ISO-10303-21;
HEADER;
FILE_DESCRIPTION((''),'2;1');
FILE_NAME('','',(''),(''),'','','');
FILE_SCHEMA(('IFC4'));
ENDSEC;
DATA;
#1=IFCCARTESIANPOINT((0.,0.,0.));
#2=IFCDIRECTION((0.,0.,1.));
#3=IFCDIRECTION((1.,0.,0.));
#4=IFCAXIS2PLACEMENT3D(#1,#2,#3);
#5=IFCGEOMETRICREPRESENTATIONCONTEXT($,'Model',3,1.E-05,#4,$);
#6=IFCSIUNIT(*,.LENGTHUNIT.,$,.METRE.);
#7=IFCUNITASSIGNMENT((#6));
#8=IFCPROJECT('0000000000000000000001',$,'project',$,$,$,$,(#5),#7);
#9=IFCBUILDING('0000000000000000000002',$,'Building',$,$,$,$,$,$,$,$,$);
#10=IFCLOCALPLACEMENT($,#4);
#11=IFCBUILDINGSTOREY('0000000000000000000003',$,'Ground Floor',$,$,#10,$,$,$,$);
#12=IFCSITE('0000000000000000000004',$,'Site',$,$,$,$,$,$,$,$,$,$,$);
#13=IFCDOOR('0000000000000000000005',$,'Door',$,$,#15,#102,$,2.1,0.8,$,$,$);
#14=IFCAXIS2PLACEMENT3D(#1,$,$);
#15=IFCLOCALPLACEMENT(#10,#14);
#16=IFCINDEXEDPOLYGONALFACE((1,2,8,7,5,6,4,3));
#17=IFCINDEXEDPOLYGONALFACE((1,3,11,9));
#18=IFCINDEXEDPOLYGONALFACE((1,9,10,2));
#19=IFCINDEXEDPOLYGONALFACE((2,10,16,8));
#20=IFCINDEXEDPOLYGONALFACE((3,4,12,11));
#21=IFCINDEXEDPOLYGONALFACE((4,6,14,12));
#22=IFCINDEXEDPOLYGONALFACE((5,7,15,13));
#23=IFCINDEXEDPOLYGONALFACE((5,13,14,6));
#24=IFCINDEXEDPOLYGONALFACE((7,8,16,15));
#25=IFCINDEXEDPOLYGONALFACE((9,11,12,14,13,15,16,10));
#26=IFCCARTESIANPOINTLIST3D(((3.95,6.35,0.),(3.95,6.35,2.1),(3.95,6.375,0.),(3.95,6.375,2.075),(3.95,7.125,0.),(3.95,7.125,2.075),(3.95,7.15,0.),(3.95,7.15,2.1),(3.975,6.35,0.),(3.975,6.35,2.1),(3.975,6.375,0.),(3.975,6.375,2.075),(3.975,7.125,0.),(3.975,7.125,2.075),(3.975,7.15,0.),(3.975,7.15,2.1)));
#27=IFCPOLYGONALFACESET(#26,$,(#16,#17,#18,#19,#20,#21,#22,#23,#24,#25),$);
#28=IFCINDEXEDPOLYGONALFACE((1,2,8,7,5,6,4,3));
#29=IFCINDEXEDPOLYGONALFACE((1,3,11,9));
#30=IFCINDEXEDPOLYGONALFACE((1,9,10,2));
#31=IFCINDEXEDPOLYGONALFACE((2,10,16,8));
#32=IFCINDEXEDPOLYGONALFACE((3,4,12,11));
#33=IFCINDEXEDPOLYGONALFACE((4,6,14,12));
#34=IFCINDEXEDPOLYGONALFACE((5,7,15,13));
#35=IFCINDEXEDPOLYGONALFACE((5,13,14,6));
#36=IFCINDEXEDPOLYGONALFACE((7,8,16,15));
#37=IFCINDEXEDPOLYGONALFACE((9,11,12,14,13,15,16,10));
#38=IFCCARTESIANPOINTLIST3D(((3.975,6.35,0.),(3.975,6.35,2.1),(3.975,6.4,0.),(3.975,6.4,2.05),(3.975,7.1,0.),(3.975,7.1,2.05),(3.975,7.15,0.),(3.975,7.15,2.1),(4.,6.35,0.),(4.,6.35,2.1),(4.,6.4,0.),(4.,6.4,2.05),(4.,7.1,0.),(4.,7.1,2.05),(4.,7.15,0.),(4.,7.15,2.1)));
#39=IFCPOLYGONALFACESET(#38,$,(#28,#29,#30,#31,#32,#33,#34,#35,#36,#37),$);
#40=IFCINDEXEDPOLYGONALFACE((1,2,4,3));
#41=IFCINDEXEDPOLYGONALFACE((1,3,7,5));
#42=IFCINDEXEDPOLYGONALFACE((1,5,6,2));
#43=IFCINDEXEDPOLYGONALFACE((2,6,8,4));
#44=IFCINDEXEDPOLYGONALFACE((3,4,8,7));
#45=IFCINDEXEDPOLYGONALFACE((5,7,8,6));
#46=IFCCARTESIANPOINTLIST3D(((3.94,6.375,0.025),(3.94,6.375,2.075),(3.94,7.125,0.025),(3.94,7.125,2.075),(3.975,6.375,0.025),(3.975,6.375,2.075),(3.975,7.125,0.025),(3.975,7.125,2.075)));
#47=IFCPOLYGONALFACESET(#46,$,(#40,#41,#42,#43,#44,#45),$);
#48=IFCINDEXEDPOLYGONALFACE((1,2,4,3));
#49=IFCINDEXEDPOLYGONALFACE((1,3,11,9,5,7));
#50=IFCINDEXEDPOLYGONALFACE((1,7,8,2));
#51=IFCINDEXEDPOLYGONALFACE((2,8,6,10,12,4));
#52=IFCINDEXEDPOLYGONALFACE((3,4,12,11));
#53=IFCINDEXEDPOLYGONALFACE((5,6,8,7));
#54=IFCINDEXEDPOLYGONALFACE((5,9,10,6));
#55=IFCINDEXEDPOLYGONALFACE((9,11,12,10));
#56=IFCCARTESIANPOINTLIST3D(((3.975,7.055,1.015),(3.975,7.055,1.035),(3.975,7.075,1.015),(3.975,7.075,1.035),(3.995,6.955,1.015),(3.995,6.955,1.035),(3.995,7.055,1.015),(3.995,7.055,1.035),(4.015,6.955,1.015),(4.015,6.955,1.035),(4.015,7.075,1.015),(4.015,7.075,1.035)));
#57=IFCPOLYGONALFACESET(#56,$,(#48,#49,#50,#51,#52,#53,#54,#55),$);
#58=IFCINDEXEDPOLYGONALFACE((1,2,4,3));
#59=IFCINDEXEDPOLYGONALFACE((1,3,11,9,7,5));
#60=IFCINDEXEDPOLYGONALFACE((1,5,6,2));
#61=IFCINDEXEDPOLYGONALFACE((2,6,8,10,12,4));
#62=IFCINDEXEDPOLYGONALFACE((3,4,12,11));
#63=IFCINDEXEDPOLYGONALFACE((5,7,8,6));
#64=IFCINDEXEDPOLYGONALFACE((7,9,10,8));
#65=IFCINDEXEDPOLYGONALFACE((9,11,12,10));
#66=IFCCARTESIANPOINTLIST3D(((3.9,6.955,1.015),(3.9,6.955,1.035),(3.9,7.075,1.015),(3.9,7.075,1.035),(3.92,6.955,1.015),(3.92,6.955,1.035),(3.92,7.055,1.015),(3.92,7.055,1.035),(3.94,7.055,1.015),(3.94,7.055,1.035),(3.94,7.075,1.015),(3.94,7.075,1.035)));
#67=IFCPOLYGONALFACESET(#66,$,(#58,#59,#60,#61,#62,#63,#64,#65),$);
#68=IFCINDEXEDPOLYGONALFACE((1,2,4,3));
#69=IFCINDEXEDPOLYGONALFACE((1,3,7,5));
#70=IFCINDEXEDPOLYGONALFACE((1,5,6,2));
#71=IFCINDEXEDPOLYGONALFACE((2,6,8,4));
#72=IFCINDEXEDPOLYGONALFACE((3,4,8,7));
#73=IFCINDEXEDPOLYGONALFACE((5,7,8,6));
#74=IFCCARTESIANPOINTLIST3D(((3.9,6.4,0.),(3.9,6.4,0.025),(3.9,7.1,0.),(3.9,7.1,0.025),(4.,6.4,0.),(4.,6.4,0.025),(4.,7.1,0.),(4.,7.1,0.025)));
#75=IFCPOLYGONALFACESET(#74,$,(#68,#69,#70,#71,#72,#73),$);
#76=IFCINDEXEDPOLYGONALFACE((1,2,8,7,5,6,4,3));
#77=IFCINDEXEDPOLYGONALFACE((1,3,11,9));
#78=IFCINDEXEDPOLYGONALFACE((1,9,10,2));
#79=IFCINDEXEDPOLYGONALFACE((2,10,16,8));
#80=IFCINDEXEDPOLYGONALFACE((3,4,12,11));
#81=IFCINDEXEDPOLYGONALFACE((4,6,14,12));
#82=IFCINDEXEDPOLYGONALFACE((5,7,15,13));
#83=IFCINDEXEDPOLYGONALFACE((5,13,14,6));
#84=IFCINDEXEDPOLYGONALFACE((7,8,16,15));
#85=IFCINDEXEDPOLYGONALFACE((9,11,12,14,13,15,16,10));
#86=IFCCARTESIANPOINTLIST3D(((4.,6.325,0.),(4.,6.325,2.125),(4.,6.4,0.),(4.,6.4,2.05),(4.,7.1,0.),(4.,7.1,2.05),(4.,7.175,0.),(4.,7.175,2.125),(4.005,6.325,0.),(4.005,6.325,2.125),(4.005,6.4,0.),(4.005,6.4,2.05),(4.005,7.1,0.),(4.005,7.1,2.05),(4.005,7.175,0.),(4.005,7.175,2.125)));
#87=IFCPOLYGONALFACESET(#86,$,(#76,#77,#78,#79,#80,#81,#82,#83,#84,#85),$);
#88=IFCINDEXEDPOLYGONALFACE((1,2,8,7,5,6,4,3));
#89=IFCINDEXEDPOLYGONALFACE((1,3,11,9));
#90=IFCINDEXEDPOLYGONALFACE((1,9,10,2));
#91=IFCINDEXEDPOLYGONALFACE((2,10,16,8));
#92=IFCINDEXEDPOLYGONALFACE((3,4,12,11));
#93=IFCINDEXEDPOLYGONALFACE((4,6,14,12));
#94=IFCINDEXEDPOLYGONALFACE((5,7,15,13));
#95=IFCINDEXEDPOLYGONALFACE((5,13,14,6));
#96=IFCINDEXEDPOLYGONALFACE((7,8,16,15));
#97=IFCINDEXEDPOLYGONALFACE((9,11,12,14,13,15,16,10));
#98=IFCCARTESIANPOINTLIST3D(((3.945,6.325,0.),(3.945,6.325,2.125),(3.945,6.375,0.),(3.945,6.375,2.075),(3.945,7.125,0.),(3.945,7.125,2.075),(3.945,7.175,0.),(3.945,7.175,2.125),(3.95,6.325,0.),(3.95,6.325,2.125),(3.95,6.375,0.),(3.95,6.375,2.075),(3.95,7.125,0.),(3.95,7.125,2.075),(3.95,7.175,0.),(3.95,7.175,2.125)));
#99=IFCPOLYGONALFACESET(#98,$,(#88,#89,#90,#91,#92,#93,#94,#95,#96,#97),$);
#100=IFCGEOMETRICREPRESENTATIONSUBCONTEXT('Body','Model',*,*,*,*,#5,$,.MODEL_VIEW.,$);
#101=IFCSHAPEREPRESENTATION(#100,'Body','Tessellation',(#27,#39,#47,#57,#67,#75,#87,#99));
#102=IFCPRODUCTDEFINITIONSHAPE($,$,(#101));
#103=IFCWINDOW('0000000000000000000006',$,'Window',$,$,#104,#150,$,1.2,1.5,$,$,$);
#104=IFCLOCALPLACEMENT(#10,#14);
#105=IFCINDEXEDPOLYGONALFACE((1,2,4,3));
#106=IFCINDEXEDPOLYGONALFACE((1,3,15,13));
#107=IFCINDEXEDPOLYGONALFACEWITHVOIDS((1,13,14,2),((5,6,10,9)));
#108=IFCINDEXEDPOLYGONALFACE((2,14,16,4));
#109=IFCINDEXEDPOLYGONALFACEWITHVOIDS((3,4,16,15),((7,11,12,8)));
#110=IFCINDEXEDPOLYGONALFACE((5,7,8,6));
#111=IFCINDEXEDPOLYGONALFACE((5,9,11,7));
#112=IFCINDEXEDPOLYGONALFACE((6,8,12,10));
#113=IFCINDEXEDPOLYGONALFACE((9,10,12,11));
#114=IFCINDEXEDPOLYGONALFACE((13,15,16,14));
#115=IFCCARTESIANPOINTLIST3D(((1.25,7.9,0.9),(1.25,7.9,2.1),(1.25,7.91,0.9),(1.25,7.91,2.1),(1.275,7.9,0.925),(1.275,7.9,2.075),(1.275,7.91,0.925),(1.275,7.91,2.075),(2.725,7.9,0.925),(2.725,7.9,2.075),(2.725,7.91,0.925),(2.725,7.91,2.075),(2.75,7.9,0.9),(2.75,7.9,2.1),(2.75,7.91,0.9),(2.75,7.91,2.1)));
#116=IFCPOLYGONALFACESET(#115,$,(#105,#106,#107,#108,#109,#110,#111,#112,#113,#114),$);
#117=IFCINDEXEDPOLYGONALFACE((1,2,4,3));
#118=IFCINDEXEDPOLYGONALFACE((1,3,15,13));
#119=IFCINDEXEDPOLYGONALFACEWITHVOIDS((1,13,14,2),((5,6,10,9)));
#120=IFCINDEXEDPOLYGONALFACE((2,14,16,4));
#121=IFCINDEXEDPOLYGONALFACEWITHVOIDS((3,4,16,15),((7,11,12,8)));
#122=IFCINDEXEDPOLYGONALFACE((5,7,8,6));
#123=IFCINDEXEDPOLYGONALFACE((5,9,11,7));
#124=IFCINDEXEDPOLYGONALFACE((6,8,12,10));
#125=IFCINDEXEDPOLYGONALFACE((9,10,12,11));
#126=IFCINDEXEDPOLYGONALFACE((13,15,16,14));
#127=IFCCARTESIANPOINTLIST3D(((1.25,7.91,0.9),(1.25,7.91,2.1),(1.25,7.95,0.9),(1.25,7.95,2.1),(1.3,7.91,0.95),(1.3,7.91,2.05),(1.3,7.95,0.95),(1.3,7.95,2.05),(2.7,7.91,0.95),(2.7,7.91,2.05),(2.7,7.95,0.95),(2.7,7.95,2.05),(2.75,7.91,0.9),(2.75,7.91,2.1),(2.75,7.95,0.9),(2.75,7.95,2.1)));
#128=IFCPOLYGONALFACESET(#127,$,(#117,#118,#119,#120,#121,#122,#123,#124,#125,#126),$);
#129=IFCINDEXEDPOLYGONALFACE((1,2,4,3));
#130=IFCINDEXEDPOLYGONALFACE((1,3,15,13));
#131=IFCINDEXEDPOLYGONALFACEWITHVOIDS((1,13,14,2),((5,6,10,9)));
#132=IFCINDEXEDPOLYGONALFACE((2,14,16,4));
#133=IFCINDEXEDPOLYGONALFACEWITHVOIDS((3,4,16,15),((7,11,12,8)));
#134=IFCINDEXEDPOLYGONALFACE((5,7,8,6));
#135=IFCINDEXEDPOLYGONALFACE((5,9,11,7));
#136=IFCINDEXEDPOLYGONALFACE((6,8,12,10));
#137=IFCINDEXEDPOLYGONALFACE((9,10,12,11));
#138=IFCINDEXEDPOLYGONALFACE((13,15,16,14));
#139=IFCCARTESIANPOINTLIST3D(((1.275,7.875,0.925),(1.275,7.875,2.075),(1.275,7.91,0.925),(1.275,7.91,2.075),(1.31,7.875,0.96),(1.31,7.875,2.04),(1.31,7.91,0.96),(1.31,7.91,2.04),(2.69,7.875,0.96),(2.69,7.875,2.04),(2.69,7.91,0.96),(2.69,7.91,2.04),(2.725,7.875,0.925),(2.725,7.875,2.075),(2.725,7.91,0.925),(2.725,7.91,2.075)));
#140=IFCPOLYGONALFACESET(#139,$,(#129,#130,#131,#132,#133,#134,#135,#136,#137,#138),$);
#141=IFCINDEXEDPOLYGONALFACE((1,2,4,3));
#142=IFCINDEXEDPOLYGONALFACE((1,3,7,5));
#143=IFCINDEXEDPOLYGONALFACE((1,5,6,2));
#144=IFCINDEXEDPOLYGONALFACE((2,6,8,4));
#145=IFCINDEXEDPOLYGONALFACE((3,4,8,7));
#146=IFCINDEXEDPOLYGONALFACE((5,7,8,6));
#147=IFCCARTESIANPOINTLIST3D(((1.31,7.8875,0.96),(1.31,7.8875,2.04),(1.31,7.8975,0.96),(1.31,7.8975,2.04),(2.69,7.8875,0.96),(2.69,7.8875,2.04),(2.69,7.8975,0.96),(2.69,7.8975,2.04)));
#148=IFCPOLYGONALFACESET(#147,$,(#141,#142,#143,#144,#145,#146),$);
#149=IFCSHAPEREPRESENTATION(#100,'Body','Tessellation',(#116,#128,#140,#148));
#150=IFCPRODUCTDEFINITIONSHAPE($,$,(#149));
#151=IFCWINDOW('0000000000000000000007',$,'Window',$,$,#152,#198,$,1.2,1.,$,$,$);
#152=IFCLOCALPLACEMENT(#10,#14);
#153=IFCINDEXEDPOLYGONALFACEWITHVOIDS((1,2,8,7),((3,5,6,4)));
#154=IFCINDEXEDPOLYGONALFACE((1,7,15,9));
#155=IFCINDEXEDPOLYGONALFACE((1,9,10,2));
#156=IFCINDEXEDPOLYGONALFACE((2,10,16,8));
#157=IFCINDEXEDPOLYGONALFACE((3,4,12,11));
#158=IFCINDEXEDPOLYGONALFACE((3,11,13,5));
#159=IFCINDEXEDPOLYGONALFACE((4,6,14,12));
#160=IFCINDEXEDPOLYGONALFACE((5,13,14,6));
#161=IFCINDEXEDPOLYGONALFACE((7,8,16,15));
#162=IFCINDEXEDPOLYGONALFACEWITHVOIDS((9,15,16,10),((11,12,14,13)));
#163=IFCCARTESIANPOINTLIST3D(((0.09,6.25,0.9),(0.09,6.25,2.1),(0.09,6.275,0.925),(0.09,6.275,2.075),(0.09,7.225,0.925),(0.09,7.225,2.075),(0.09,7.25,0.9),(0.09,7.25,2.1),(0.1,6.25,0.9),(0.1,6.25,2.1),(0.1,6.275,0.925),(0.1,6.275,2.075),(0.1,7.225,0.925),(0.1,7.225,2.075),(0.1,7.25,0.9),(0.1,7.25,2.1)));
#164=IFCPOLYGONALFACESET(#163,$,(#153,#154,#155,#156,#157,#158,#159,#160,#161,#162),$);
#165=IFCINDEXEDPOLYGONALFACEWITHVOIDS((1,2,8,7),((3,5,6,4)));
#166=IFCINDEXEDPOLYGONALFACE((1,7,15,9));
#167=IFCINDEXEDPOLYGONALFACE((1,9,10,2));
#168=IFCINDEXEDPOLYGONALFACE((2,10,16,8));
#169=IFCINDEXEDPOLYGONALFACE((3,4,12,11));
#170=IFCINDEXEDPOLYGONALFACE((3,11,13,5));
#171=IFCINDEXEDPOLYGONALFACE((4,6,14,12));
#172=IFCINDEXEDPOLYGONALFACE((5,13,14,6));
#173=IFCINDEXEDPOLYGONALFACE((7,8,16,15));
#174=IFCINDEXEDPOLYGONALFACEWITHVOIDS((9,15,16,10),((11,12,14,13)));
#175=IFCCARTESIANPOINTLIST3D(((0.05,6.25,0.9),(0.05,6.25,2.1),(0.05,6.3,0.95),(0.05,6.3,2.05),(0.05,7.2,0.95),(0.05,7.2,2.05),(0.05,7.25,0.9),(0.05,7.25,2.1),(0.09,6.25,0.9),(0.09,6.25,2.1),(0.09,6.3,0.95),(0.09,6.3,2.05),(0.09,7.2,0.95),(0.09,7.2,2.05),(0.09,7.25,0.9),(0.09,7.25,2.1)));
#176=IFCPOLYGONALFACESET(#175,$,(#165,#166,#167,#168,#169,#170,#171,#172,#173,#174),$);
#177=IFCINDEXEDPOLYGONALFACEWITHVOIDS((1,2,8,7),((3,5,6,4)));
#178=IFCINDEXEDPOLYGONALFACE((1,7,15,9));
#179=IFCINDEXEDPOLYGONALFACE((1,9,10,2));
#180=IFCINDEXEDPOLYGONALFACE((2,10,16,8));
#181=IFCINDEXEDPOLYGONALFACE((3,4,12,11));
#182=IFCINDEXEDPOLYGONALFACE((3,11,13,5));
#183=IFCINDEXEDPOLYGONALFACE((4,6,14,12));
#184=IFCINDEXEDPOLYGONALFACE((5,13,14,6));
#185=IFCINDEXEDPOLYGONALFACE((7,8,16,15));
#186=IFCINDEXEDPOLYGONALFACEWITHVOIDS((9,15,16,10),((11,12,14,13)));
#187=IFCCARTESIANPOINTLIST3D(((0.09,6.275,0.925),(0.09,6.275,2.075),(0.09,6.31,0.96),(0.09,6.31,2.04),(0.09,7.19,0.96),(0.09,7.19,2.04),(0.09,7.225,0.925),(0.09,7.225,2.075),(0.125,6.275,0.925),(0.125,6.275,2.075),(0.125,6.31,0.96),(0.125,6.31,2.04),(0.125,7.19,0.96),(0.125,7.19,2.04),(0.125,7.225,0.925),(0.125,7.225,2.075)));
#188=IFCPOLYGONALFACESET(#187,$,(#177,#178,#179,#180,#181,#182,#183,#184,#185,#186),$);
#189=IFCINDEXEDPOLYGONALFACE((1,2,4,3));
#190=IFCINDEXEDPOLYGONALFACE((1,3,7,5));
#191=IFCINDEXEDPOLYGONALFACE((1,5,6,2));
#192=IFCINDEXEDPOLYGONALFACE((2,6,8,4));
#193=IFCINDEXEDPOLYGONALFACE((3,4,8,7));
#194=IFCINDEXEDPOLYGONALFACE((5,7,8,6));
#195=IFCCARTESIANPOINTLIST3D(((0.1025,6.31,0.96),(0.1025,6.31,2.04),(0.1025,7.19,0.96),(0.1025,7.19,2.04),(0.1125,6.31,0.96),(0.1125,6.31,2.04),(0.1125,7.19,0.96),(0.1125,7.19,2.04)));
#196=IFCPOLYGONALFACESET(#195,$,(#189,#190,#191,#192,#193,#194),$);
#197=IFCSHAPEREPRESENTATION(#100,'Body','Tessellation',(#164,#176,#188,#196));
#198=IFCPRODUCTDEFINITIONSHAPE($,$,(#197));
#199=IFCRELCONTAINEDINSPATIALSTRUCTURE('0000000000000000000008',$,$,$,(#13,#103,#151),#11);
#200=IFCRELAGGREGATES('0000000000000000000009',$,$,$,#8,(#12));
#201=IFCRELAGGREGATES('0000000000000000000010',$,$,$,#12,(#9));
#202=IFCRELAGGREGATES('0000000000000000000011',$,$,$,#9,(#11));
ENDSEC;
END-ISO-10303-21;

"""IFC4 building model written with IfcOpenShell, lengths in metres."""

from ifc_helpers import new_model, si_unit, frame, origin_with_axes, place, context, subcontext, project, spatial, line, indexed_curve, outline, extrude, element, save


model = new_model("IFC4")

# Units and contexts
model_context = context("Model", 3, precision=1e-05, world=origin_with_axes())
body_context = subcontext(model_context, "Body", "Model", "MODEL_VIEW")
ifc_project = project(units=[si_unit("LENGTHUNIT", "METRE")], contexts=[model_context])

# Site, building, storey
site = spatial("IfcSite", under=ifc_project, Name="Site")
building = spatial("IfcBuilding", under=site, Name="Building")
storey_placement = place(None, origin_with_axes())
storey = spatial("IfcBuildingStorey", under=building, at=storey_placement, Name="Ground Floor")

# Door
door_1_placement = place(storey_placement, frame((4.0, 6.35, 0.0), z_axis=(0.0, 0.0, 1.0), x_axis=(0.0, 1.0, 0.0)))
element("IfcDoor", 1, at=door_1_placement, inside=storey, Name="Door", OverallHeight=2.1, OverallWidth=0.8, context=body_context, shape_type="SweptSolid", body=[
    extrude(outline(indexed_curve([(0.0, 0.0), (0.0, 2.1), (0.8, 2.1), (0.8, 0.0), (0.775, 0.0), (0.775, 2.075), (0.025, 2.075), (0.025, 0.0)], segments=[line(1, 2, 3, 4, 5, 6, 7, 8, 1)])), frame((0.0, 0.025, 0.0), z_axis=(0.0, -1.0, 0.0), x_axis=(1.0, 0.0, 0.0)), (0.0, 0.0, -1.0), 0.025),
    extrude(outline(indexed_curve([(0.0, 0.0), (0.0, 2.1), (0.8, 2.1), (0.8, 0.0), (0.75, 0.0), (0.75, 2.05), (0.05, 2.05), (0.05, 0.0)], segments=[line(1, 2, 3, 4, 5, 6, 7, 8, 1)])), frame((0.0, 0.0, 0.0), z_axis=(0.0, -1.0, 0.0), x_axis=(1.0, 0.0, 0.0)), (0.0, 0.0, -1.0), 0.025),
    extrude(outline(indexed_curve([(0.0, 0.0), (0.75, 0.0), (0.75, 0.035), (0.0, 0.035)], segments=[line(1, 2, 3, 4, 1)])), frame((0.025, 0.025, 0.025), z_axis=(0.0, 0.0, 1.0), x_axis=(1.0, 0.0, 0.0)), (0.0, 0.0, 1.0), 2.05),
    extrude(outline(indexed_curve([(0.0, 0.0), (0.0, -0.04), (-0.12, -0.04), (-0.12, -0.02), (-0.02, -0.02), (-0.02, 0.0)], segments=[line(1, 2, 3, 4, 5, 6, 1)])), frame((0.725, 0.025, 1.015), z_axis=(0.0, 0.0, 1.0), x_axis=(1.0, 0.0, 0.0)), (0.0, 0.0, 1.0), 0.02),
    extrude(outline(indexed_curve([(0.0, 0.0), (0.0, 0.04), (-0.12, 0.04), (-0.12, 0.02), (-0.02, 0.02), (-0.02, 0.0)], segments=[line(1, 2, 3, 4, 5, 6, 1)])), frame((0.725, 0.06, 1.015), z_axis=(0.0, 0.0, 1.0), x_axis=(1.0, 0.0, 0.0)), (0.0, 0.0, 1.0), 0.02),
    extrude(outline(indexed_curve([(0.0, 0.0), (0.7, 0.0), (0.7, 0.1), (0.0, 0.1)], segments=[line(1, 2, 3, 4, 1)])), frame((0.05, 0.0, 0.0), z_axis=(0.0, 0.0, 1.0), x_axis=(1.0, 0.0, 0.0)), (0.0, 0.0, 1.0), 0.025),
    extrude(outline(indexed_curve([(0.0, 0.0), (0.0, 2.125), (0.85, 2.125), (0.85, 0.0), (0.775, 0.0), (0.775, 2.05), (0.075, 2.05), (0.075, 0.0)], segments=[line(1, 2, 3, 4, 5, 6, 7, 8, 1)])), frame((-0.025, -0.005, 0.0), z_axis=(0.0, -1.0, 0.0), x_axis=(1.0, 0.0, 0.0)), (0.0, 0.0, -1.0), 0.005),
    extrude(outline(indexed_curve([(0.0, 0.0), (0.0, 2.125), (0.85, 2.125), (0.85, 0.0), (0.8, 0.0), (0.8, 2.075), (0.05, 2.075), (0.05, 0.0)], segments=[line(1, 2, 3, 4, 5, 6, 7, 8, 1)])), frame((-0.025, 0.05, 0.0), z_axis=(0.0, -1.0, 0.0), x_axis=(1.0, 0.0, 0.0)), (0.0, 0.0, -1.0), 0.005),
])

# Windows
window_1_placement = place(storey_placement, frame((2.75, 8.0, 0.9), z_axis=(0.0, 0.0, 1.0), x_axis=(-1.0, 0.0, 0.0)))
element("IfcWindow", 2, at=window_1_placement, inside=storey, Name="Window", OverallHeight=1.2, OverallWidth=1.5, context=body_context, shape_type="SweptSolid", body=[
    extrude(outline(indexed_curve([(0.0, 0.0), (1.5, 0.0), (1.5, 1.2), (0.0, 1.2)], segments=[line(1, 2, 3, 4, 1)]), holes=[indexed_curve([(0.025, 0.025), (1.475, 0.025), (1.475, 1.175), (0.025, 1.175)], segments=[line(1, 2, 3, 4, 1)])]), frame((0.0, 0.09, 0.0), z_axis=(0.0, -1.0, 0.0), x_axis=(1.0, 0.0, 0.0)), (0.0, 0.0, -1.0), 0.01),
    extrude(outline(indexed_curve([(0.0, 0.0), (1.5, 0.0), (1.5, 1.2), (0.0, 1.2)], segments=[line(1, 2, 3, 4, 1)]), holes=[indexed_curve([(0.05, 0.05), (1.45, 0.05), (1.45, 1.15), (0.05, 1.15)], segments=[line(1, 2, 3, 4, 1)])]), frame((0.0, 0.05, 0.0), z_axis=(0.0, -1.0, 0.0), x_axis=(1.0, 0.0, 0.0)), (0.0, 0.0, -1.0), 0.04),
    extrude(outline(indexed_curve([(0.0, 0.0), (1.45, 0.0), (1.45, 1.15), (0.0, 1.15)], segments=[line(1, 2, 3, 4, 1)]), holes=[indexed_curve([(0.035, 0.035), (1.415, 0.035), (1.415, 1.115), (0.035, 1.115)], segments=[line(1, 2, 3, 4, 1)])]), frame((0.025, 0.09, 0.025), z_axis=(0.0, -1.0, 0.0), x_axis=(1.0, 0.0, 0.0)), (0.0, 0.0, -1.0), 0.035),
    extrude(outline(indexed_curve([(0.035, 0.035), (1.415, 0.035), (1.415, 1.115), (0.035, 1.115)], segments=[line(1, 2, 3, 4, 1)])), frame((0.025, 0.1025, 0.025), z_axis=(0.0, -1.0, 0.0), x_axis=(1.0, 0.0, 0.0)), (0.0, 0.0, -1.0), 0.01),
])
window_2_placement = place(storey_placement, frame((0.0, 7.25, 0.9), z_axis=(0.0, 0.0, 1.0), x_axis=(0.0, -1.0, 0.0)))
element("IfcWindow", 3, at=window_2_placement, inside=storey, Name="Window", OverallHeight=1.2, OverallWidth=1.0, context=body_context, shape_type="SweptSolid", body=[
    extrude(outline(indexed_curve([(0.0, 0.0), (1.0, 0.0), (1.0, 1.2), (0.0, 1.2)], segments=[line(1, 2, 3, 4, 1)]), holes=[indexed_curve([(0.025, 0.025), (0.975, 0.025), (0.975, 1.175), (0.025, 1.175)], segments=[line(1, 2, 3, 4, 1)])]), frame((0.0, 0.09, 0.0), z_axis=(0.0, -1.0, 0.0), x_axis=(1.0, 0.0, 0.0)), (0.0, 0.0, -1.0), 0.01),
    extrude(outline(indexed_curve([(0.0, 0.0), (1.0, 0.0), (1.0, 1.2), (0.0, 1.2)], segments=[line(1, 2, 3, 4, 1)]), holes=[indexed_curve([(0.05, 0.05), (0.95, 0.05), (0.95, 1.15), (0.05, 1.15)], segments=[line(1, 2, 3, 4, 1)])]), frame((0.0, 0.05, 0.0), z_axis=(0.0, -1.0, 0.0), x_axis=(1.0, 0.0, 0.0)), (0.0, 0.0, -1.0), 0.04),
    extrude(outline(indexed_curve([(0.0, 0.0), (0.95, 0.0), (0.95, 1.15), (0.0, 1.15)], segments=[line(1, 2, 3, 4, 1)]), holes=[indexed_curve([(0.035, 0.035), (0.915, 0.035), (0.915, 1.115), (0.035, 1.115)], segments=[line(1, 2, 3, 4, 1)])]), frame((0.025, 0.09, 0.025), z_axis=(0.0, -1.0, 0.0), x_axis=(1.0, 0.0, 0.0)), (0.0, 0.0, -1.0), 0.035),
    extrude(outline(indexed_curve([(0.035, 0.035), (0.915, 0.035), (0.915, 1.115), (0.035, 1.115)], segments=[line(1, 2, 3, 4, 1)])), frame((0.025, 0.1025, 0.025), z_axis=(0.0, -1.0, 0.0), x_axis=(1.0, 0.0, 0.0)), (0.0, 0.0, -1.0), 0.01),
])

save(model, "model.ifc")
